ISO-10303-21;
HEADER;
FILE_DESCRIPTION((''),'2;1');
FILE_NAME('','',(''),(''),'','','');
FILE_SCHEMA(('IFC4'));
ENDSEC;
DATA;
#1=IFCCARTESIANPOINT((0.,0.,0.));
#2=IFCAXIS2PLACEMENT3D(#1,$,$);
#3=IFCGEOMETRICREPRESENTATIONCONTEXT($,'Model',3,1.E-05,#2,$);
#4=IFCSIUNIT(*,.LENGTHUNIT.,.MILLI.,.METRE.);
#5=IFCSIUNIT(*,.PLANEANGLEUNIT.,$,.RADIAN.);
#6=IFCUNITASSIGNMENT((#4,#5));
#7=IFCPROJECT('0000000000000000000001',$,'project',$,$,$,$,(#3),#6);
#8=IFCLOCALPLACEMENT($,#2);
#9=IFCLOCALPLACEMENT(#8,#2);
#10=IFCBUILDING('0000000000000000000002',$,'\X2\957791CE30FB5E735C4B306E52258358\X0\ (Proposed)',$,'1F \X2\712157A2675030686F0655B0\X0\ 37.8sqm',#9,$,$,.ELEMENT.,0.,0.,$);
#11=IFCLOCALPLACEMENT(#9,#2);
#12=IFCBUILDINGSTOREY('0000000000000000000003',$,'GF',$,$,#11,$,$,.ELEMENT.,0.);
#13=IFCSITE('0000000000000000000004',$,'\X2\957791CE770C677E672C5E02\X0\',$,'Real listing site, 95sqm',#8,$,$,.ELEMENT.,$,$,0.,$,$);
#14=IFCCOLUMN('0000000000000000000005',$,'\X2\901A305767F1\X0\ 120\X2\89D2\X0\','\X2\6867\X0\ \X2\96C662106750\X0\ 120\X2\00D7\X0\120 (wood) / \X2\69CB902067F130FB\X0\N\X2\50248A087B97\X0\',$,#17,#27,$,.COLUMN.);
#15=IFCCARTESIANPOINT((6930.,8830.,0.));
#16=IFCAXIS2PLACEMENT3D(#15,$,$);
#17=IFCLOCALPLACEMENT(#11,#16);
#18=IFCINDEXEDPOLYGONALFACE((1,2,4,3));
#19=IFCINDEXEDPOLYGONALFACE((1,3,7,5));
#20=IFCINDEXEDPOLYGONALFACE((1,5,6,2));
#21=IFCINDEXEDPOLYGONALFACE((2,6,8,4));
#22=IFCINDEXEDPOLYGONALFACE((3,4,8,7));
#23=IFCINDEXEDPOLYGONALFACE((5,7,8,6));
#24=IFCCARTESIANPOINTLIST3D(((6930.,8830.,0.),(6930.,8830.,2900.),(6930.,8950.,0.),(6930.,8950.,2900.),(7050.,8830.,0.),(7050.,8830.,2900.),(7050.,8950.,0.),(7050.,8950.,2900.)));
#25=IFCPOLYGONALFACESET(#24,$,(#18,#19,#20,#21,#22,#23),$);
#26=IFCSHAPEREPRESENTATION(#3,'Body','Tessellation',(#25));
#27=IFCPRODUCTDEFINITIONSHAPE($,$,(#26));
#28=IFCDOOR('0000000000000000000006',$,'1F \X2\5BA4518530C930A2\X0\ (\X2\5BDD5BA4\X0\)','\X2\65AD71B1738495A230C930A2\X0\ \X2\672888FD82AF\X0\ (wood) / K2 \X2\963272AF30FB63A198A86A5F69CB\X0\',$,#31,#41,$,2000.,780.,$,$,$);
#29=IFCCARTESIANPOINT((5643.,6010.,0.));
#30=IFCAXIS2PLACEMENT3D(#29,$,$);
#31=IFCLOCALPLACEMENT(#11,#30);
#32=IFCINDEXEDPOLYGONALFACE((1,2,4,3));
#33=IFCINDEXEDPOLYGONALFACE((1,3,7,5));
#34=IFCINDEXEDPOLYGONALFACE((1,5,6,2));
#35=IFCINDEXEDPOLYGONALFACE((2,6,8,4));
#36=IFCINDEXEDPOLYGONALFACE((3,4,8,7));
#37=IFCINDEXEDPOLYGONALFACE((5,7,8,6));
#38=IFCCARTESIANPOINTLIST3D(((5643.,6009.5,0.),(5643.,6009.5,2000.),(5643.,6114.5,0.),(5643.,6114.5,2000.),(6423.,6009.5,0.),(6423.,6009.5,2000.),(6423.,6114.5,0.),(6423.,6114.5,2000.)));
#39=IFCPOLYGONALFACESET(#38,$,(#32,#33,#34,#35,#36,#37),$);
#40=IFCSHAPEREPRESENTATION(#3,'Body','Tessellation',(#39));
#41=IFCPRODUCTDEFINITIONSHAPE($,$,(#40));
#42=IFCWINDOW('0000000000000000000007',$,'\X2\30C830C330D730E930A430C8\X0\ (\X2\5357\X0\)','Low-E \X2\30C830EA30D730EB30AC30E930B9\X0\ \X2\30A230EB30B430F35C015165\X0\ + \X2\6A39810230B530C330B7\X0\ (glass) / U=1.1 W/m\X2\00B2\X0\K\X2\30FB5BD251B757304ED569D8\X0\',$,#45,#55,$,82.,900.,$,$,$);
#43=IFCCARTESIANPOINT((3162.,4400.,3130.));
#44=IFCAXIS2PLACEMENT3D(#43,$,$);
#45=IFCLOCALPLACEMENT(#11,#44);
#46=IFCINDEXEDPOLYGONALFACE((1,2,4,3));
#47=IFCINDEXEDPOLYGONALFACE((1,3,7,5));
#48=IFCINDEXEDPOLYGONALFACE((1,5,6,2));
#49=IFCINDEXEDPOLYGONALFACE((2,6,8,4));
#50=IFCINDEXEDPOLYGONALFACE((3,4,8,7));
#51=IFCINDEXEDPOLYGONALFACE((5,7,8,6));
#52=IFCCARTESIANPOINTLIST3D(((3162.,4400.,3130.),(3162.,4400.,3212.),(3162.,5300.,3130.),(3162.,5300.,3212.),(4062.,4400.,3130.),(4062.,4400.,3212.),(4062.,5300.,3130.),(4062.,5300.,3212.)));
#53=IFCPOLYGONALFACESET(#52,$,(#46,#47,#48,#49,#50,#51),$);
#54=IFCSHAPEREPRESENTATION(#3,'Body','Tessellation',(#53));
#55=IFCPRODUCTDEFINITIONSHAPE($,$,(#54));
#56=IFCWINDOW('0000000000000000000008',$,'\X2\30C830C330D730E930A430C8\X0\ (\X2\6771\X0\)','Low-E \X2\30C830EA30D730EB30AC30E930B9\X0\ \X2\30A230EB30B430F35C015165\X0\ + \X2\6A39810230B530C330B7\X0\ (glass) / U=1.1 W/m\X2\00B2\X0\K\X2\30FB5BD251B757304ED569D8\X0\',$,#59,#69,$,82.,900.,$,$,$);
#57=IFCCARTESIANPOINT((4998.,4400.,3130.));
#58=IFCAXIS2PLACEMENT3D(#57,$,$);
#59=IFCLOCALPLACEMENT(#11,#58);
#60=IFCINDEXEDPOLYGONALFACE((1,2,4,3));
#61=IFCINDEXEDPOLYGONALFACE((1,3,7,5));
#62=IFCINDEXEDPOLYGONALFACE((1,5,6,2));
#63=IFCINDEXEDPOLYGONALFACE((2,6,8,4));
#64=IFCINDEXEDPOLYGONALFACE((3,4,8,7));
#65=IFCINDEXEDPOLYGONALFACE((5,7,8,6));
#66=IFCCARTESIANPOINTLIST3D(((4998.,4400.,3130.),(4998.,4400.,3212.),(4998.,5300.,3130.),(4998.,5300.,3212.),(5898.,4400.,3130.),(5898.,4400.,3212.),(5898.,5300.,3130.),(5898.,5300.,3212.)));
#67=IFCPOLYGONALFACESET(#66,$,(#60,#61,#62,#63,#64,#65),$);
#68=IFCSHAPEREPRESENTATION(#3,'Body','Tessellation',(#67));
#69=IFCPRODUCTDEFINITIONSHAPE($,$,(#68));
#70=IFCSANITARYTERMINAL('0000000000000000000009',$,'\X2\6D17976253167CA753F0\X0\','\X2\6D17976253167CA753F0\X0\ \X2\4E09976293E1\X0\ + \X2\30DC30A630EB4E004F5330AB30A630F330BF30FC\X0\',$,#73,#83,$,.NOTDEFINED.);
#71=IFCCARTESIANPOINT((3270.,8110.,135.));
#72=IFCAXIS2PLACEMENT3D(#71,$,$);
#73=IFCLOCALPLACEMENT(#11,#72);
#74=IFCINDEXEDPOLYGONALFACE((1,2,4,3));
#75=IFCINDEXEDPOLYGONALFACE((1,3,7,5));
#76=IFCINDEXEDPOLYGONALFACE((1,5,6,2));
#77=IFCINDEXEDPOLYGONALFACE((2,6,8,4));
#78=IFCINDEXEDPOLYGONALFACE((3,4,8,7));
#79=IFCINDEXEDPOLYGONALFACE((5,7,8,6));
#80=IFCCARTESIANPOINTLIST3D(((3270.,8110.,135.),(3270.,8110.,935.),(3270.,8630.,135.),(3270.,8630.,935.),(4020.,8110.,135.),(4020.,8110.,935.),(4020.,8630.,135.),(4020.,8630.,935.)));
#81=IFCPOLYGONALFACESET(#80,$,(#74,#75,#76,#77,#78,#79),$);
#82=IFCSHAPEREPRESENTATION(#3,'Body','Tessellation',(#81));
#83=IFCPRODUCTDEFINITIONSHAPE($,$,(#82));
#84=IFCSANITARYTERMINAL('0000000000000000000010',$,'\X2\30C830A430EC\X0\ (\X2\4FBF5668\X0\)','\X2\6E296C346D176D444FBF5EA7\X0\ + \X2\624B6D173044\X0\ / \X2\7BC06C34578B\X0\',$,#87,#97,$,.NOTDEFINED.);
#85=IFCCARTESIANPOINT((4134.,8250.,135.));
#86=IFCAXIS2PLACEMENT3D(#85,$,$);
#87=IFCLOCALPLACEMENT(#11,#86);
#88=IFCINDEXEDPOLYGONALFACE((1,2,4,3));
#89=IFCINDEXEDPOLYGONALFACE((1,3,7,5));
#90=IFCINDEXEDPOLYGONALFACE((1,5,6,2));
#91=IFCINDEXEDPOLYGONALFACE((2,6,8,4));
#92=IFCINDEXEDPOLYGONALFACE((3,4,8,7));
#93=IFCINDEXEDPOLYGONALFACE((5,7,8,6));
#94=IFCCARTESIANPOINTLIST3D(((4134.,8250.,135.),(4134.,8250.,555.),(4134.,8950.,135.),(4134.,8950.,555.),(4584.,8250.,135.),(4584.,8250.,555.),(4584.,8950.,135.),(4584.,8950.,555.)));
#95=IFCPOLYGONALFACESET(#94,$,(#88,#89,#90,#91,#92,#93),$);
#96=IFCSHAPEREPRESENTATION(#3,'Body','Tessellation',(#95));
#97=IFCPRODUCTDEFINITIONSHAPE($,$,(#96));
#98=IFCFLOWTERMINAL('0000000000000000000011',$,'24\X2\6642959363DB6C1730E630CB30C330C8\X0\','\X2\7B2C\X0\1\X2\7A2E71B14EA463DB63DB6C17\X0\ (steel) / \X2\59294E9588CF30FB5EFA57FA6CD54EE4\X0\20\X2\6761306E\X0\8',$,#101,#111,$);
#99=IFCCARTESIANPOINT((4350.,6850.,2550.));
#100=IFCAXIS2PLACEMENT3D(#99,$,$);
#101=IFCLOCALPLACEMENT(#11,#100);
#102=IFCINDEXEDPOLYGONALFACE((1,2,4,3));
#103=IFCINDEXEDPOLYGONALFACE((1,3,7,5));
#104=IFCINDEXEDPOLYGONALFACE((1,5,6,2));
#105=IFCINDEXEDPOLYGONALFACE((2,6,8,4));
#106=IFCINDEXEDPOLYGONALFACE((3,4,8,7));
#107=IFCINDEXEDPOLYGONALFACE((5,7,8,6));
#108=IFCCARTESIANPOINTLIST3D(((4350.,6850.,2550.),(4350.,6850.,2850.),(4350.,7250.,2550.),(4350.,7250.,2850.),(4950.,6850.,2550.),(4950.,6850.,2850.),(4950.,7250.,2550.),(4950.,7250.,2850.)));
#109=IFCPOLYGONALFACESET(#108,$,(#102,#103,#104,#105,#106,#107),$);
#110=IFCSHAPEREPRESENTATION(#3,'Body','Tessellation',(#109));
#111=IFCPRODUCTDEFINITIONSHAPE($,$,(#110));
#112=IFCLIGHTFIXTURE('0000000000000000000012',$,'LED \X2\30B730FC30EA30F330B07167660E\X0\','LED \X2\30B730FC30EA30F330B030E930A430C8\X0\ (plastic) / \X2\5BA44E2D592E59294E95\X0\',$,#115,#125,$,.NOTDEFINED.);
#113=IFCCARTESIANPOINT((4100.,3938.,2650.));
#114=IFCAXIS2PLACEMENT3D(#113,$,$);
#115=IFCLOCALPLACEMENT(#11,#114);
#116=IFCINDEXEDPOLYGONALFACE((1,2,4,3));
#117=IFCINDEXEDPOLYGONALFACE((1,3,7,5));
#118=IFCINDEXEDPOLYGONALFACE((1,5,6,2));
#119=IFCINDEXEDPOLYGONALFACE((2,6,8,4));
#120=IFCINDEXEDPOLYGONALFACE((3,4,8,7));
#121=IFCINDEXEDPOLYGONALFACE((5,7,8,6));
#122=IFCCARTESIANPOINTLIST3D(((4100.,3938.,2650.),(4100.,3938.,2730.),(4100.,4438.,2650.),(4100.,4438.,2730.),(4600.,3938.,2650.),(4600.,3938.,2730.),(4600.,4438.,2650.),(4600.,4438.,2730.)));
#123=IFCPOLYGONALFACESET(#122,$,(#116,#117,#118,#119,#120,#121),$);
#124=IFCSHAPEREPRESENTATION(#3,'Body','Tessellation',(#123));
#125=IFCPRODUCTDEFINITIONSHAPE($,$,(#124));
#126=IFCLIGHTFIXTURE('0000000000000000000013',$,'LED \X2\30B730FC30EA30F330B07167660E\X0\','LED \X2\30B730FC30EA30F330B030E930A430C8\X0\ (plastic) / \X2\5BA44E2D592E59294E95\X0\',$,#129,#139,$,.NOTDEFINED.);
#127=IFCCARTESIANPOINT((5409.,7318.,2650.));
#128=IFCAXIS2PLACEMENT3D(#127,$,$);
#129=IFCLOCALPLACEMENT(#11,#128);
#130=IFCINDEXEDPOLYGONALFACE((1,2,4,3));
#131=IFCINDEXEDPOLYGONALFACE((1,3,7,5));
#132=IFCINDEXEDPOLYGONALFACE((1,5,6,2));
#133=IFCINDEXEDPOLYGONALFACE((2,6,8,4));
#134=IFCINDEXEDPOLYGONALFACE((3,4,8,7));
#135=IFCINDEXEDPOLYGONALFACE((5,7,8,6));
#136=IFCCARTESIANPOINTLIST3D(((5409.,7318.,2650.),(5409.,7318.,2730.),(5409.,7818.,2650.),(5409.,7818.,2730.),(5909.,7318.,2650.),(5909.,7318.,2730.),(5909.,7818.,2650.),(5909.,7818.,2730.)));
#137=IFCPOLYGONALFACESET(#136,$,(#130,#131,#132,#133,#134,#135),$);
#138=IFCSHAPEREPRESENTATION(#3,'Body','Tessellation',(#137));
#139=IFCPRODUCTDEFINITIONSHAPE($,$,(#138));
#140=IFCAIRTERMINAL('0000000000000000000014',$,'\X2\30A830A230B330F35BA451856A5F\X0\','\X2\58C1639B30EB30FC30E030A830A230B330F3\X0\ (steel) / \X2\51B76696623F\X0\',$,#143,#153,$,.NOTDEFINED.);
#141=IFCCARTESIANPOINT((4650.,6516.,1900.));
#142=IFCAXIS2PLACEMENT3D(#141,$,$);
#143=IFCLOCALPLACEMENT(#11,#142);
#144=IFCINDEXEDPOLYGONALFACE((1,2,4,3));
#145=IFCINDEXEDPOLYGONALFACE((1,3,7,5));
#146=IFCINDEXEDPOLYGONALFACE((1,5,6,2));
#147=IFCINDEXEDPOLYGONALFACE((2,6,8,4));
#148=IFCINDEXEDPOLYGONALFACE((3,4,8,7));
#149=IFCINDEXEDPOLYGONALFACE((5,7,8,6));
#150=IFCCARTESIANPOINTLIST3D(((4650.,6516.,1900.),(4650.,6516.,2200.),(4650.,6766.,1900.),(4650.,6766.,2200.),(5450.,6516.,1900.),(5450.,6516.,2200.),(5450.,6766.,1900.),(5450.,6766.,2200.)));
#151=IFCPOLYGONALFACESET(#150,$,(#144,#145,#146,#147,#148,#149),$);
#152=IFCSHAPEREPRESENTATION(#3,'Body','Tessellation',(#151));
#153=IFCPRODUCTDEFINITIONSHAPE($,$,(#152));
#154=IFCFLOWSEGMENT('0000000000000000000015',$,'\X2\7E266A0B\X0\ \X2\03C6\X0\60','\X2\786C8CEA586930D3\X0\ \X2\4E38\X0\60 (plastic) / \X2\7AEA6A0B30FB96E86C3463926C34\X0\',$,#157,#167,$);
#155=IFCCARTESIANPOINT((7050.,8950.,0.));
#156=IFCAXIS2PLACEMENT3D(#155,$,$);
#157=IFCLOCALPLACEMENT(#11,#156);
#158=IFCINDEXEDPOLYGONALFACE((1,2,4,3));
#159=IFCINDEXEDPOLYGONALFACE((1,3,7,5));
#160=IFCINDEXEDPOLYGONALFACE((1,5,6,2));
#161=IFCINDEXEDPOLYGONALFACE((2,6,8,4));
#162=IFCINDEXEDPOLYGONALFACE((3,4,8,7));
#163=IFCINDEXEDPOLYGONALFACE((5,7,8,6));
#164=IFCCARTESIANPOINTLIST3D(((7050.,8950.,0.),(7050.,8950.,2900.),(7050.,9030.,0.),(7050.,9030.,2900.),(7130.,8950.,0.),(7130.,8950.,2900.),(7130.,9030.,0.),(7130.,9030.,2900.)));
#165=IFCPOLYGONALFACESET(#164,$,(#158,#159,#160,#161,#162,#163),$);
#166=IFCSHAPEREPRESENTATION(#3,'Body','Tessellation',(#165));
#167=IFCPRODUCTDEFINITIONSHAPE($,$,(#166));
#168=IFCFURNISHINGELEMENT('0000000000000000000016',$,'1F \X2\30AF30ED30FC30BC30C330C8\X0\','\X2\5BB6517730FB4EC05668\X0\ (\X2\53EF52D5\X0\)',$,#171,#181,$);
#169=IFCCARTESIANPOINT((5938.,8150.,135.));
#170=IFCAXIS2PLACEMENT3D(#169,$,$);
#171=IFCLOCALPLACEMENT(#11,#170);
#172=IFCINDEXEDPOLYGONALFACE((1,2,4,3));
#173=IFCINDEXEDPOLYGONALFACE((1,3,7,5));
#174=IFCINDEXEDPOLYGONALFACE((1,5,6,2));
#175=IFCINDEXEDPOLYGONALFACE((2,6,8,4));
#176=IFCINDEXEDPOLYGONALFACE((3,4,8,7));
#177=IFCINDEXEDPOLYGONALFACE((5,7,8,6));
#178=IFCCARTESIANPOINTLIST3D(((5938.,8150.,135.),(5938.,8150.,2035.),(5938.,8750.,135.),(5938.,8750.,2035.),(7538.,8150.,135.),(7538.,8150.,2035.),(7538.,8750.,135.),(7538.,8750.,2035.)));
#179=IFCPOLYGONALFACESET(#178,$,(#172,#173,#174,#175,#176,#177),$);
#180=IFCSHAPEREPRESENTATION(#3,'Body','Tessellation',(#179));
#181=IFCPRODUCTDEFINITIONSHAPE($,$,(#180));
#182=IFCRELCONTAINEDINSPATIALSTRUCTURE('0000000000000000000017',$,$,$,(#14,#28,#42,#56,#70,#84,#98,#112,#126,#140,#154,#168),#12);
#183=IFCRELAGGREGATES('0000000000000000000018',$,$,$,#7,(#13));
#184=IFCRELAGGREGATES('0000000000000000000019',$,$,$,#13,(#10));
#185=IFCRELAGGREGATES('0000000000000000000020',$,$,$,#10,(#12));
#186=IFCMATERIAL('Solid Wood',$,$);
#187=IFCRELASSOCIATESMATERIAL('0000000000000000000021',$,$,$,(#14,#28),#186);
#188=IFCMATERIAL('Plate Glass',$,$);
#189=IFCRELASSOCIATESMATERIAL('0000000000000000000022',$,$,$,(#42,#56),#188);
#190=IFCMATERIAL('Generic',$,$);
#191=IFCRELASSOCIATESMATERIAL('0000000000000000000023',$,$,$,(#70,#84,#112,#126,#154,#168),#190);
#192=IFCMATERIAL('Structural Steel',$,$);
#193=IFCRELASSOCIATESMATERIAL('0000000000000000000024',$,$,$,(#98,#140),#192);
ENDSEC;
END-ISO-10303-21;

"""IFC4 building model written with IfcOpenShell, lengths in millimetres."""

from ifc_helpers import new_model, si_unit, frame, frame_2d, origin, place, context, project, spatial, rectangle, extrude, material, element, save


model = new_model("IFC4")

# Units and contexts
model_context = context("Model", 3, precision=1e-05, world=origin())
ifc_project = project(units=[si_unit("LENGTHUNIT", "METRE", prefix="MILLI"), si_unit("PLANEANGLEUNIT", "RADIAN")], contexts=[model_context])

# Site, building, storey
site_placement = place(None, origin())
site = spatial("IfcSite", under=ifc_project, at=site_placement, Name="長野県松本市", ObjectType="Real listing site, 95sqm", CompositionType="ELEMENT", RefElevation=0.0)
building_placement = place(site_placement, origin())
building = spatial("IfcBuilding", under=site, at=building_placement, Name="長野・平屋の別荘 (Proposed)", ObjectType="1F 無垢材と漆喰 37.8sqm", CompositionType="ELEMENT", ElevationOfRefHeight=0.0, ElevationOfTerrain=0.0)
storey_placement = place(building_placement, origin())
storey = spatial("IfcBuildingStorey", under=building, at=storey_placement, Name="GF", CompositionType="ELEMENT", Elevation=0.0)

# Column
ifc_material_1 = material(Name="Solid Wood")
column_1_placement = place(storey_placement, frame((6930.0, 8830.0, 0.0)))
element("IfcColumn", 1, at=column_1_placement, inside=storey, material=ifc_material_1, Name="通し柱 120角", Description="桧 集成材 120×120 (wood) / 構造柱・N値計算", PredefinedType="COLUMN", context=model_context, shape_type="SweptSolid", body=[
    extrude(rectangle(XDim=120.0, YDim=120.0, at=frame_2d((60.0, 60.0))), frame((6930.0, 8830.0, 0.0)), (0.0, 0.0, 1.0), 2900.0),
])

# Door
door_placement = place(storey_placement, frame((5643.0, 6010.0, 0.0)))
element("IfcDoor", 2, at=door_placement, inside=storey, material=ifc_material_1, Name="1F 室内ドア (寝室)", Description="断熱玄関ドア 木製芯 (wood) / K2 防犯・採風機構", OverallHeight=2000.0, OverallWidth=780.0, context=model_context, shape_type="SweptSolid", body=[
    extrude(rectangle(XDim=780.0, YDim=105.0, at=frame_2d((390.0, 52.0))), frame((5643.0, 6010.0, 0.0)), (0.0, 0.0, 1.0), 2000.0),
])

# Windows
ifc_material_2 = material(Name="Plate Glass")
window_1_placement = place(storey_placement, frame((3162.0, 4400.0, 3130.0)))
element("IfcWindow", 3, at=window_1_placement, inside=storey, material=ifc_material_2, Name="トップライト (南)", Description="Low-E トリプルガラス アルゴン封入 + 樹脂サッシ (glass) / U=1.1 W/m²K・寒冷地仕様", OverallHeight=82.0, OverallWidth=900.0, context=model_context, shape_type="SweptSolid", body=[
    extrude(rectangle(XDim=900.0, YDim=900.0, at=frame_2d((450.0, 450.0))), frame((3162.0, 4400.0, 3130.0)), (0.0, 0.0, 1.0), 82.0),
])
window_2_placement = place(storey_placement, frame((4998.0, 4400.0, 3130.0)))
element("IfcWindow", 4, at=window_2_placement, inside=storey, material=ifc_material_2, Name="トップライト (東)", Description="Low-E トリプルガラス アルゴン封入 + 樹脂サッシ (glass) / U=1.1 W/m²K・寒冷地仕様", OverallHeight=82.0, OverallWidth=900.0, context=model_context, shape_type="SweptSolid", body=[
    extrude(rectangle(XDim=900.0, YDim=900.0, at=frame_2d((450.0, 450.0))), frame((4998.0, 4400.0, 3130.0)), (0.0, 0.0, 1.0), 82.0),
])

# Sanitary terminals
ifc_material_3 = material(Name="Generic")
sanitary_terminal_1_placement = place(storey_placement, frame((3270.0, 8110.0, 135.0)))
element("IfcSanitaryTerminal", 5, at=sanitary_terminal_1_placement, inside=storey, material=ifc_material_3, Name="洗面化粧台", Description="洗面化粧台 三面鏡 + ボウル一体カウンター", PredefinedType="NOTDEFINED", context=model_context, shape_type="SweptSolid", body=[
    extrude(rectangle(XDim=750.0, YDim=520.0, at=frame_2d((375.0, 260.0))), frame((3270.0, 8110.0, 135.0)), (0.0, 0.0, 1.0), 800.0),
])
sanitary_terminal_2_placement = place(storey_placement, frame((4134.0, 8250.0, 135.0)))
element("IfcSanitaryTerminal", 6, at=sanitary_terminal_2_placement, inside=storey, material=ifc_material_3, Name="トイレ (便器)", Description="温水洗浄便座 + 手洗い / 節水型", PredefinedType="NOTDEFINED", context=model_context, shape_type="SweptSolid", body=[
    extrude(rectangle(XDim=450.0, YDim=700.0, at=frame_2d((225.0, 350.0))), frame((4134.0, 8250.0, 135.0)), (0.0, 0.0, 1.0), 420.0),
])

# Flow terminal
ifc_material_4 = material(Name="Structural Steel")
flow_terminal_placement = place(storey_placement, frame((4350.0, 6850.0, 2550.0)))
element("IfcFlowTerminal", 7, at=flow_terminal_placement, inside=storey, material=ifc_material_4, Name="24時間換気ユニット", Description="第1種熱交換換気 (steel) / 天井裏・建基法令20条の8", context=model_context, shape_type="SweptSolid", body=[
    extrude(rectangle(XDim=600.0, YDim=400.0, at=frame_2d((300.0, 200.0))), frame((4350.0, 6850.0, 2550.0)), (0.0, 0.0, 1.0), 300.0),
])

# Light fixtures
light_fixture_1_placement = place(storey_placement, frame((4100.0, 3938.0, 2650.0)))
element("IfcLightFixture", 8, at=light_fixture_1_placement, inside=storey, material=ifc_material_3, Name="LED シーリング照明", Description="LED シーリングライト (plastic) / 室中央天井", PredefinedType="NOTDEFINED", context=model_context, shape_type="SweptSolid", body=[
    extrude(rectangle(XDim=500.0, YDim=500.0, at=frame_2d((250.0, 250.0))), frame((4100.0, 3938.0, 2650.0)), (0.0, 0.0, 1.0), 80.0),
])
light_fixture_2_placement = place(storey_placement, frame((5409.0, 7318.0, 2650.0)))
element("IfcLightFixture", 9, at=light_fixture_2_placement, inside=storey, material=ifc_material_3, Name="LED シーリング照明", Description="LED シーリングライト (plastic) / 室中央天井", PredefinedType="NOTDEFINED", context=model_context, shape_type="SweptSolid", body=[
    extrude(rectangle(XDim=500.0, YDim=500.0, at=frame_2d((250.0, 250.0))), frame((5409.0, 7318.0, 2650.0)), (0.0, 0.0, 1.0), 80.0),
])

# Air terminal
air_terminal_placement = place(storey_placement, frame((4650.0, 6516.0, 1900.0)))
element("IfcAirTerminal", 10, at=air_terminal_placement, inside=storey, material=ifc_material_4, Name="エアコン室内機", Description="壁掛ルームエアコン (steel) / 冷暖房", PredefinedType="NOTDEFINED", context=model_context, shape_type="SweptSolid", body=[
    extrude(rectangle(XDim=800.0, YDim=250.0, at=frame_2d((400.0, 125.0))), frame((4650.0, 6516.0, 1900.0)), (0.0, 0.0, 1.0), 300.0),
])

# Flow segment
flow_segment_placement = place(storey_placement, frame((7050.0, 8950.0, 0.0)))
element("IfcFlowSegment", 11, at=flow_segment_placement, inside=storey, material=ifc_material_3, Name="縦樋 φ60", Description="硬質塩ビ 丸60 (plastic) / 竪樋・雨水排水", context=model_context, shape_type="SweptSolid", body=[
    extrude(rectangle(XDim=80.0, YDim=80.0, at=frame_2d((40.0, 40.0))), frame((7050.0, 8950.0, 0.0)), (0.0, 0.0, 1.0), 2900.0),
])

# Furnishing element
furnishing_placement = place(storey_placement, frame((5938.0, 8150.0, 135.0)))
element("IfcFurnishingElement", 12, at=furnishing_placement, inside=storey, material=ifc_material_3, Name="1F クローゼット", Description="家具・什器 (可動)", context=model_context, shape_type="SweptSolid", body=[
    extrude(rectangle(XDim=1600.0, YDim=600.0, at=frame_2d((800.0, 300.0))), frame((5938.0, 8150.0, 135.0)), (0.0, 0.0, 1.0), 1900.0),
])

save(model, "model.ifc")
